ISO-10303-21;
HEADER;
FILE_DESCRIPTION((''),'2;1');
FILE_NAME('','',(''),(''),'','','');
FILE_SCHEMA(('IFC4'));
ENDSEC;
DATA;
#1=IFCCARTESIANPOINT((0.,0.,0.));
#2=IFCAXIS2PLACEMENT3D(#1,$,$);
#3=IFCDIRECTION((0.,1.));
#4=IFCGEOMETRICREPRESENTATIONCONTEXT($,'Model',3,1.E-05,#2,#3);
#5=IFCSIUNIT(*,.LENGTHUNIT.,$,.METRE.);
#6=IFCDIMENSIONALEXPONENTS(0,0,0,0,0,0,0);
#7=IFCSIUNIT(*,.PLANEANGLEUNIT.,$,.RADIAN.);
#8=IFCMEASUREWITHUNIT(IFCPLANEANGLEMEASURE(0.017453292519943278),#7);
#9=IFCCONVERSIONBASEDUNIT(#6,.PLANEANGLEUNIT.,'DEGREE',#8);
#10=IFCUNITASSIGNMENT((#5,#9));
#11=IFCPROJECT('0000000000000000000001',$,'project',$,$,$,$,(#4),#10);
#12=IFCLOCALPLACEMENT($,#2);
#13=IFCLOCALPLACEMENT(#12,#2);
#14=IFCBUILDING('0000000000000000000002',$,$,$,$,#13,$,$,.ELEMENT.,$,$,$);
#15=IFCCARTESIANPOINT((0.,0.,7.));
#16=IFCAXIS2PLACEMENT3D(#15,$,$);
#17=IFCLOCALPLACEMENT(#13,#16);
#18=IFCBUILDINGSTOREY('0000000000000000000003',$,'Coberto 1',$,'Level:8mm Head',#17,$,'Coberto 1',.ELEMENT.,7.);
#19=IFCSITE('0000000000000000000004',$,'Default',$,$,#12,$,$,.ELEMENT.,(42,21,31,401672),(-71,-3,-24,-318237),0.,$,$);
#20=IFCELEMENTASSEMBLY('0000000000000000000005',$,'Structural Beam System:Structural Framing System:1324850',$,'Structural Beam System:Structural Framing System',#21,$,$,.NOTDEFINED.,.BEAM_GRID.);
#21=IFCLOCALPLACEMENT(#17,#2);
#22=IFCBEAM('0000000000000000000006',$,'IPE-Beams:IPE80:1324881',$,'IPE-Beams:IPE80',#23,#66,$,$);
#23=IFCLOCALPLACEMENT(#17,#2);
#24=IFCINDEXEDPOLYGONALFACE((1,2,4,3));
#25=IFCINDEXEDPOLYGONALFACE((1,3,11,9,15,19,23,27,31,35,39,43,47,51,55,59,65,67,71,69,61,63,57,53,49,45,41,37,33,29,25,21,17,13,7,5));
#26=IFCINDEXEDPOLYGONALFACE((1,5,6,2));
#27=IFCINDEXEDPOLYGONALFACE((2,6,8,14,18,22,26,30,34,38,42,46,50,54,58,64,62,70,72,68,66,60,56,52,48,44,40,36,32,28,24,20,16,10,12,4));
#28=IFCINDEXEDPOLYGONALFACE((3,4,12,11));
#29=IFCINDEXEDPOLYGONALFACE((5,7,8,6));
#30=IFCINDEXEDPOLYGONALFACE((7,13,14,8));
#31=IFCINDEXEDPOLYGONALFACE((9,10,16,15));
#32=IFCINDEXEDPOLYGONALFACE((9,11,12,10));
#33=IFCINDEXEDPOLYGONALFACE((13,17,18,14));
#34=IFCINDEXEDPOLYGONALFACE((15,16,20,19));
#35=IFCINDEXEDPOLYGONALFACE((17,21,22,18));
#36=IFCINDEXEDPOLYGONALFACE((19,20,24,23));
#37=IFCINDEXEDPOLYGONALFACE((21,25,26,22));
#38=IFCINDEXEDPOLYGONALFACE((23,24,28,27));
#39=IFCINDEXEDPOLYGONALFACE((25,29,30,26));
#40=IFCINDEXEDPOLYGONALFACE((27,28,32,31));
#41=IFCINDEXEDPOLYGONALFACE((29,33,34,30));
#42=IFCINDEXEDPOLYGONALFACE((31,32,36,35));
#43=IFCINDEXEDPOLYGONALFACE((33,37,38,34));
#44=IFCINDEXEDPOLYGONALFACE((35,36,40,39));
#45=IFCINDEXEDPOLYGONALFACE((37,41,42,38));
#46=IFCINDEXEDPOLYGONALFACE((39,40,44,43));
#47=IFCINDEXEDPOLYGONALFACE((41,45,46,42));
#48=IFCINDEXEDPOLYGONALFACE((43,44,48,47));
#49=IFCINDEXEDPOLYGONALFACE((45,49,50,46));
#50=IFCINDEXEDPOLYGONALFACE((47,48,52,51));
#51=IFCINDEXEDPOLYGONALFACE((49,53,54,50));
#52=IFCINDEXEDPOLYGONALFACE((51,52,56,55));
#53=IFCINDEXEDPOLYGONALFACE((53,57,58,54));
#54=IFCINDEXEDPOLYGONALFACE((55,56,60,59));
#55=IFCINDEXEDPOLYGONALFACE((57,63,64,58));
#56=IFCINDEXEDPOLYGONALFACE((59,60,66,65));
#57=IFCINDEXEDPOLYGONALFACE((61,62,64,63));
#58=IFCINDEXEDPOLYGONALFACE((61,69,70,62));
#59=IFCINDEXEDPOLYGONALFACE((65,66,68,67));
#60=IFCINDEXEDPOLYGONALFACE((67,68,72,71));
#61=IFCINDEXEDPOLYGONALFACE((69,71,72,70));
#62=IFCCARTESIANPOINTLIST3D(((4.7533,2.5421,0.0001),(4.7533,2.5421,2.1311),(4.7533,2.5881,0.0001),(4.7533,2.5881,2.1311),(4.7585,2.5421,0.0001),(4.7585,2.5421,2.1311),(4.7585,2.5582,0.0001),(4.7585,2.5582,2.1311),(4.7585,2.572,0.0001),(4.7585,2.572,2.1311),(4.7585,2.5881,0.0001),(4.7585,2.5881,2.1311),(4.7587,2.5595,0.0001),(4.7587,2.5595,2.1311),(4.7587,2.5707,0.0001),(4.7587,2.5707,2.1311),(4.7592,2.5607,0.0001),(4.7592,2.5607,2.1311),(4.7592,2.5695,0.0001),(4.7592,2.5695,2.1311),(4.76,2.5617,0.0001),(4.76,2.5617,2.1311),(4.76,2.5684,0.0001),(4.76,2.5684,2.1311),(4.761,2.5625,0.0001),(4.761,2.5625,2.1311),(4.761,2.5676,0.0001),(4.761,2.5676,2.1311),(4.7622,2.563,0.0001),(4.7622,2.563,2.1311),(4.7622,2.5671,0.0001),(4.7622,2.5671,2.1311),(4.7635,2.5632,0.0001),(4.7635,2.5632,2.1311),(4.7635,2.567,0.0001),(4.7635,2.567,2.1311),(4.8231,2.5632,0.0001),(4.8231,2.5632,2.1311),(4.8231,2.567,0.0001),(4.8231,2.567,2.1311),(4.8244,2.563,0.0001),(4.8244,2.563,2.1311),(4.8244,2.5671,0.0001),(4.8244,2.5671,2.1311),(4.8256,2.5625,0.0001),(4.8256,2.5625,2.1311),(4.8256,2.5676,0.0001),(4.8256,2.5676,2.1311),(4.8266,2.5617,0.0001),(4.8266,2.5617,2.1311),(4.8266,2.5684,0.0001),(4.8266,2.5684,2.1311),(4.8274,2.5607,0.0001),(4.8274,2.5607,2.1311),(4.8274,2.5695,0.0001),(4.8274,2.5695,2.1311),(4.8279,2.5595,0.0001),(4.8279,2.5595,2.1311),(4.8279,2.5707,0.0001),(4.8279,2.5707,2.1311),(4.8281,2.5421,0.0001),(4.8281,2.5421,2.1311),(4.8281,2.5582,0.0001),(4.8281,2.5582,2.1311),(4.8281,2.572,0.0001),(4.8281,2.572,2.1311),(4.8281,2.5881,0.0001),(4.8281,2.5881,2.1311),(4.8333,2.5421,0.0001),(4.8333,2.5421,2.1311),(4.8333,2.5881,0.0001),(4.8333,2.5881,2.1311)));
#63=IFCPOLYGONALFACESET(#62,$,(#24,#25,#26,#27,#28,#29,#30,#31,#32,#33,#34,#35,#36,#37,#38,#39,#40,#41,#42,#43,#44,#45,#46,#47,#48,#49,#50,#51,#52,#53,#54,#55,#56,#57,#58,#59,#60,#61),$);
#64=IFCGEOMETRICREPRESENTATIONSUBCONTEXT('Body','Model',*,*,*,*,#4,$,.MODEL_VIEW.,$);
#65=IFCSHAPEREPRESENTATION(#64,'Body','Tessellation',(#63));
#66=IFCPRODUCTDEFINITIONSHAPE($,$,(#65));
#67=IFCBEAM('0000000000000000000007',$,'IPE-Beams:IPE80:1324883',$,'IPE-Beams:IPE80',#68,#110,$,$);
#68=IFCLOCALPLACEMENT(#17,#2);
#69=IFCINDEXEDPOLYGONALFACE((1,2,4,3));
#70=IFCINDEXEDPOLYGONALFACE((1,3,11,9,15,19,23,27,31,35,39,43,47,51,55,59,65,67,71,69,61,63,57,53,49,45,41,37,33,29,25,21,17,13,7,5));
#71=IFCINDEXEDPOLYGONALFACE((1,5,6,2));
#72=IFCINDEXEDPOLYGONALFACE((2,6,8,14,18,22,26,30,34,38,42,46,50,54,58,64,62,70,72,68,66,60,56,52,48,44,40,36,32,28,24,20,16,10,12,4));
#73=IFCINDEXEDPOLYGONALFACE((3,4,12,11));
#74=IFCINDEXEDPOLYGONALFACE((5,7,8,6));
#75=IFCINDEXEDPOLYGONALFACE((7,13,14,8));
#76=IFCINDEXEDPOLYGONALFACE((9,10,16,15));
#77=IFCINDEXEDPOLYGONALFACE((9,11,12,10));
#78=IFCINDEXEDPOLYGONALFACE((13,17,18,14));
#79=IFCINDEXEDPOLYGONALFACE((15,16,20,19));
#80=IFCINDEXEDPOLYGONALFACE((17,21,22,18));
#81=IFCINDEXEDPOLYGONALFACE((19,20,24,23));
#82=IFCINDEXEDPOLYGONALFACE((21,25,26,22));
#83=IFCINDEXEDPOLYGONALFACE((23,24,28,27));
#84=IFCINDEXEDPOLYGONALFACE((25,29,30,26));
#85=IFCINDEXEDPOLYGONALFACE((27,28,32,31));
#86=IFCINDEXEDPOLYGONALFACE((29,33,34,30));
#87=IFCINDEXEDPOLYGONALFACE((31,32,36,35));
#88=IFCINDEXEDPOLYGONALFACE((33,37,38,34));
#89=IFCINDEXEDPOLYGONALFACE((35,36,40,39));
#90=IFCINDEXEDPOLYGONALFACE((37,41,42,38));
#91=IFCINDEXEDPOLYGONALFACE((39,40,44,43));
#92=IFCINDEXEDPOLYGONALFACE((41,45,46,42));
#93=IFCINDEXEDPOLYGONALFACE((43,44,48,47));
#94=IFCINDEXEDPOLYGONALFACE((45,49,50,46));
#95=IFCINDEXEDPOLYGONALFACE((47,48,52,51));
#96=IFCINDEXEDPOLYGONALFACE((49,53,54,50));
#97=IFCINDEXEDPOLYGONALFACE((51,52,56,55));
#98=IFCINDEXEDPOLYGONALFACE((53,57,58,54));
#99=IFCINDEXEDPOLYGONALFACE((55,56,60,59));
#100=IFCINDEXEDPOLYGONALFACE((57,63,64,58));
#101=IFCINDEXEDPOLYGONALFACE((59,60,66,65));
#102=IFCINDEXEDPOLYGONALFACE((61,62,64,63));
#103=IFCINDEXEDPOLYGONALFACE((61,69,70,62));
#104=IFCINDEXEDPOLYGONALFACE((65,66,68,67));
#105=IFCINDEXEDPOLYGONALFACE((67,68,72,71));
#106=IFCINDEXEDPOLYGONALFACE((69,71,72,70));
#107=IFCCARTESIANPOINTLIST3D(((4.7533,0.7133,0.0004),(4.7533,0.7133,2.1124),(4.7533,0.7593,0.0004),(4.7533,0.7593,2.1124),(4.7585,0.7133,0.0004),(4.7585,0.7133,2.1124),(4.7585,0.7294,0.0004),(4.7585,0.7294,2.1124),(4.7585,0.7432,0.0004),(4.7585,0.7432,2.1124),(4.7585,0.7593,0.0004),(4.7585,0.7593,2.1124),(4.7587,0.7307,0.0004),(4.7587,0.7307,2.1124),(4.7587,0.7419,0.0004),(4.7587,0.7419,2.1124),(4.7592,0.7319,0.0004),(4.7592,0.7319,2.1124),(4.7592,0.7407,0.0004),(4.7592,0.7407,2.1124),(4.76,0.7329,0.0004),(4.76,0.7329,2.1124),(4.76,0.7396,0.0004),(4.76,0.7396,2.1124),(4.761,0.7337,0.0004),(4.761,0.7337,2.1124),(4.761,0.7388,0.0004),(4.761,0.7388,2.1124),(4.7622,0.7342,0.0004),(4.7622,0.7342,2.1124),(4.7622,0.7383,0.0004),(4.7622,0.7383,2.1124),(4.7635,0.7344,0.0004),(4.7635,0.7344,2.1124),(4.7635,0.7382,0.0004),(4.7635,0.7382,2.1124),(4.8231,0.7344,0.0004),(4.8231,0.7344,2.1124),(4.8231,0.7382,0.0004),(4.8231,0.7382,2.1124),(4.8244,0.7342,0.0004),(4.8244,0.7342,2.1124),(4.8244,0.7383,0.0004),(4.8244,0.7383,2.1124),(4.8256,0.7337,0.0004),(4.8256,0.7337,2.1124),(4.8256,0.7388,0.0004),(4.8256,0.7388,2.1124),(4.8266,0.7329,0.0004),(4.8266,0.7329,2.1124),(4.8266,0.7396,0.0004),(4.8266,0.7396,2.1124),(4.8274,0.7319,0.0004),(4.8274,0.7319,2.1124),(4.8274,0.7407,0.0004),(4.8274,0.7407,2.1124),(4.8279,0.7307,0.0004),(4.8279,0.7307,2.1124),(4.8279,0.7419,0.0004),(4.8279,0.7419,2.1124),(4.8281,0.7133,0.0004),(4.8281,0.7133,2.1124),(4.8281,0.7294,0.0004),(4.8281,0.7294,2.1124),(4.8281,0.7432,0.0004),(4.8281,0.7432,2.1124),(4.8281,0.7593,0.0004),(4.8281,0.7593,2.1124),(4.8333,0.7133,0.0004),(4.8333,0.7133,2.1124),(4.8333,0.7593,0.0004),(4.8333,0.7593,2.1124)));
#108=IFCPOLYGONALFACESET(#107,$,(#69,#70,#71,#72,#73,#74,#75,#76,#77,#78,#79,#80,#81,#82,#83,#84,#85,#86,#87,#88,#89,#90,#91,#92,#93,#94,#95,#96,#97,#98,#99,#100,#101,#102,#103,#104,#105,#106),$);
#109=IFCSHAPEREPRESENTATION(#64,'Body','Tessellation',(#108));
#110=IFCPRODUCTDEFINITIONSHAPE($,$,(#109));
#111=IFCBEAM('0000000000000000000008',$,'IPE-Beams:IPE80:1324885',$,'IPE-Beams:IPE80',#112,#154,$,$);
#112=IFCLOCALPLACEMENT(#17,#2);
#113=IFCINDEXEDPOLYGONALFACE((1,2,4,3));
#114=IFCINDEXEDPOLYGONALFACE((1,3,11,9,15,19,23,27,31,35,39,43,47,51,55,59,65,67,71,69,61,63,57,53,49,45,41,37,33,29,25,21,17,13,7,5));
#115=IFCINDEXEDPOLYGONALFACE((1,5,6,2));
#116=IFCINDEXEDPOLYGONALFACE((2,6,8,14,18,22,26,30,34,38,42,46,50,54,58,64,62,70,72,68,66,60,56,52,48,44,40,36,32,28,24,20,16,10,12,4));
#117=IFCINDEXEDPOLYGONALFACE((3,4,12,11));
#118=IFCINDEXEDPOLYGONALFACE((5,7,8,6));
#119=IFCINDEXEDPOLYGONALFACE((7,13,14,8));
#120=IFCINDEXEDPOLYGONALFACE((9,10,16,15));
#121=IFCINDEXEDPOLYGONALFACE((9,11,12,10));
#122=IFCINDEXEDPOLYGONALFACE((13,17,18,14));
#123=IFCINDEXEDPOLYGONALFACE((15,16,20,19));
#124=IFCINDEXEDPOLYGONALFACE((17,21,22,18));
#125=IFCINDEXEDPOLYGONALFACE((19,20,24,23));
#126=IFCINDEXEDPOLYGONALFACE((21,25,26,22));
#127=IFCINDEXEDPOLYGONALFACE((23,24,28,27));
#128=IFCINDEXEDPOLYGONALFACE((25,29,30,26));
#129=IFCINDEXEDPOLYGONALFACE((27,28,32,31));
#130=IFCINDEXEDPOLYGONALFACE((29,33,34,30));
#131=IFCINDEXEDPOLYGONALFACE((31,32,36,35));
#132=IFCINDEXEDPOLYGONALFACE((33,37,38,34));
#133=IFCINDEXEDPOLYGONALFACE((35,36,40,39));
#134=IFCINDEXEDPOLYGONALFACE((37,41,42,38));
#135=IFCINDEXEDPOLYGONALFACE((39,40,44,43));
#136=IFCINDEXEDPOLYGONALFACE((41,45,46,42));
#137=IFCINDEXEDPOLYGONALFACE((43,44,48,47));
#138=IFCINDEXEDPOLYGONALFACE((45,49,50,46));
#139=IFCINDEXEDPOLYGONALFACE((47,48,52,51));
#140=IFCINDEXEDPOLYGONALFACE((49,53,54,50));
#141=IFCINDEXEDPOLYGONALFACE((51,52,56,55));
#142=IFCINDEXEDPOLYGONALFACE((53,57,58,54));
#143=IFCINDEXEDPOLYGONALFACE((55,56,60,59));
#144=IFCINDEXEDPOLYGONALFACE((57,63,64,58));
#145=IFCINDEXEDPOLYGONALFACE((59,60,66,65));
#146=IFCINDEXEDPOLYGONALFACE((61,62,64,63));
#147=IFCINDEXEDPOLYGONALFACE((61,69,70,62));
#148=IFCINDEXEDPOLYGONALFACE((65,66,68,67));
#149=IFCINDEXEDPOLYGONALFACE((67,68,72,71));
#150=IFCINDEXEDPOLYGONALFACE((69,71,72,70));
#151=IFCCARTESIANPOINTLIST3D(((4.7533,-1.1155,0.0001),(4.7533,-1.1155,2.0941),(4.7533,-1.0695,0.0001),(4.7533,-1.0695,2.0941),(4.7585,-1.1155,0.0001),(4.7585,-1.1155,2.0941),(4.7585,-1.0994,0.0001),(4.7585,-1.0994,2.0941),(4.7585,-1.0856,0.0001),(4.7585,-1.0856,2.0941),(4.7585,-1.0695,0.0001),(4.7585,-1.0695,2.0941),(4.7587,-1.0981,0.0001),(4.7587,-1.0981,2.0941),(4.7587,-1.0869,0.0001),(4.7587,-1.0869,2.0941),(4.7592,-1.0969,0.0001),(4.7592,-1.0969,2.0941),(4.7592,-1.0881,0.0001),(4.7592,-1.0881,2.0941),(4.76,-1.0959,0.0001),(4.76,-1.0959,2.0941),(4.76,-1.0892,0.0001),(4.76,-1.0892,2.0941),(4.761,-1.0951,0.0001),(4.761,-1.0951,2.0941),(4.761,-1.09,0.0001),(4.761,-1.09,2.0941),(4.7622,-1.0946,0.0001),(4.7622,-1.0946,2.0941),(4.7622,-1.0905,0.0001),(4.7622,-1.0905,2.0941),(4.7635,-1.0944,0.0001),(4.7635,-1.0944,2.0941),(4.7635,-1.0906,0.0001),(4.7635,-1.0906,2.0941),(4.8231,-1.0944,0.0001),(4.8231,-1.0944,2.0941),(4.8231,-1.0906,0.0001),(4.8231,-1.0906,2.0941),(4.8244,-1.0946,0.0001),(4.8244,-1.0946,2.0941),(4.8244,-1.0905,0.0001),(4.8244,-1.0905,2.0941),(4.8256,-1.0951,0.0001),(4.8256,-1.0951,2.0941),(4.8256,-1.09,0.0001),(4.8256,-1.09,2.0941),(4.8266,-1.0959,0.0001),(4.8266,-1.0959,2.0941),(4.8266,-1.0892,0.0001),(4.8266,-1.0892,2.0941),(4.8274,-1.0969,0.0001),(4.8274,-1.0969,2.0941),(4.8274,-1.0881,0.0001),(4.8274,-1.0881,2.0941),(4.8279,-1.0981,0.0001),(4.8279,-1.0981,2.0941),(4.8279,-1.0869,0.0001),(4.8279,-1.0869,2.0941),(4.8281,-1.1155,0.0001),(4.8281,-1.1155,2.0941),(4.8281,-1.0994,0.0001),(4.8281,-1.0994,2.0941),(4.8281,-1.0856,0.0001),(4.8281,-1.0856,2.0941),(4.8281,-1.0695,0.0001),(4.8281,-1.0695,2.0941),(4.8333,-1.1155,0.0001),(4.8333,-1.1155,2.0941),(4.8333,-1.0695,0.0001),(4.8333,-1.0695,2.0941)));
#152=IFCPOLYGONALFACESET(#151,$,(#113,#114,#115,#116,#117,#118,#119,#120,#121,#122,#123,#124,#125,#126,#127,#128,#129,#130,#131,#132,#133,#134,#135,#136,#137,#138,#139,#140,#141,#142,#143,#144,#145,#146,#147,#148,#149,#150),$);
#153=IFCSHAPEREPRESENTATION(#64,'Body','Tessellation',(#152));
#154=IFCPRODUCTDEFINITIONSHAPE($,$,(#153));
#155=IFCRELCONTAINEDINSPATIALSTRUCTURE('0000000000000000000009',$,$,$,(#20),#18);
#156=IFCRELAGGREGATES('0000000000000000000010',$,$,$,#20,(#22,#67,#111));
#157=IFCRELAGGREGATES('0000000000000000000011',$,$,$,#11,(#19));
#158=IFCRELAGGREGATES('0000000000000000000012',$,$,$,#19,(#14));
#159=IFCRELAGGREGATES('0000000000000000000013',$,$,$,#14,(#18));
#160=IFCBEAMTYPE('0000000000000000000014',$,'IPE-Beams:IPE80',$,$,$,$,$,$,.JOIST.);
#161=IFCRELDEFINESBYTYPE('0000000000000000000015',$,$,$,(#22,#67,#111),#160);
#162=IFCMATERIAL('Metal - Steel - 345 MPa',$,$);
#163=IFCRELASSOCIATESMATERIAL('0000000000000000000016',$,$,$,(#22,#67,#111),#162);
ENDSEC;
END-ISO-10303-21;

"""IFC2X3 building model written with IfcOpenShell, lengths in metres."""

from ifc_helpers import new_model, entity, si_unit, converted_unit, direction, frame, frame_2d, origin, place, context, subcontext, project, spatial, polyline, circle_curve, parameter, trimmed, segment, composite_curve, outline, extrude, material, type_object, element, aggregate, save


model = new_model("IFC2X3")

# Units and contexts
model_context = context("Model", 3, precision=1e-05, world=origin(), true_north=direction((0.0, 1.0)))
body_context = subcontext(model_context, "Body", "Model", "MODEL_VIEW")
ifc_project = project(units=[si_unit("LENGTHUNIT", "METRE"), converted_unit("PLANEANGLEUNIT", "DEGREE", entity("IfcPlaneAngleMeasure", 0.017453292519943278), si_unit("PLANEANGLEUNIT", "RADIAN"), dimensions=[0, 0, 0, 0, 0, 0, 0])], contexts=[model_context])

# Site, building, storey
site_placement = place(None, origin())
site = spatial("IfcSite", under=ifc_project, at=site_placement, Name="Default", CompositionType="ELEMENT", RefLatitude=(42, 21, 31, 401672), RefLongitude=(-71, -3, -24, -318237), RefElevation=0.0)
building_placement = place(site_placement, origin())
building = spatial("IfcBuilding", under=site, at=building_placement, CompositionType="ELEMENT")
storey_placement = place(building_placement, frame((0.0, 0.0, 7.0)))
storey = spatial("IfcBuildingStorey", under=building, at=storey_placement, Name="Coberto 1", ObjectType="Level:8mm Head", LongName="Coberto 1", CompositionType="ELEMENT", Elevation=7.0)

# Shared definitions
ifc_material_1 = material(Name="Metal - Steel - 345 MPa")

# Element assembly, beams
assembly_1_placement = place(storey_placement, origin())
assembly_1 = element("IfcElementAssembly", 1, at=assembly_1_placement, inside=storey, Name="Structural Beam System:Structural Framing System:1324850", ObjectType="Structural Beam System:Structural Framing System", AssemblyPlace="NOTDEFINED", PredefinedType="BEAM_GRID")
beam_type_1 = type_object("IfcBeamType", Name="IPE-Beams:IPE80", PredefinedType="JOIST")
beam_1_placement = place(assembly_1_placement, frame((4.7533, 2.5651, 2.1312), z_axis=(1.0, 0.0, 0.0), x_axis=(0.0, 0.0, -1.0)))
beam_1 = element("IfcBeam", 2, at=beam_1_placement, type_object=beam_type_1, material=ifc_material_1, Name="IPE-Beams:IPE80:1324881", ObjectType="IPE-Beams:IPE80", context=body_context, shape_type="SweptSolid", body=[
    extrude(outline(composite_curve([segment(polyline([(0.0348, -0.023), (0.04, -0.023)]), True, "CONTINUOUS"), segment(polyline([(0.04, -0.023), (0.04, 0.023)]), True, "CONTINUOUS"), segment(polyline([(0.04, 0.023), (0.0348, 0.023)]), True, "CONTINUOUS"), segment(polyline([(0.0348, 0.023), (0.0348, 0.0069)]), True, "CONTINUOUS"), segment(trimmed(circle_curve(frame_2d((0.0298, 0.0069), x_axis=(1.0, 0.0)), 0.005), [parameter(270.0)], [parameter(0.0)], True, "PARAMETER"), False, "CONTINUOUS"), segment(polyline([(0.0298, 0.0019), (-0.0298, 0.0019)]), True, "CONTINUOUS"), segment(trimmed(circle_curve(frame_2d((-0.0298, 0.0069), x_axis=(0.0, -1.0)), 0.005), [parameter(270.0)], [parameter(0.0)], True, "PARAMETER"), False, "CONTINUOUS"), segment(polyline([(-0.0348, 0.0069), (-0.0348, 0.023)]), True, "CONTINUOUS"), segment(polyline([(-0.0348, 0.023), (-0.04, 0.023)]), True, "CONTINUOUS"), segment(polyline([(-0.04, 0.023), (-0.04, -0.023)]), True, "CONTINUOUS"), segment(polyline([(-0.04, -0.023), (-0.0348, -0.023)]), True, "CONTINUOUS"), segment(polyline([(-0.0348, -0.023), (-0.0348, -0.0069)]), True, "CONTINUOUS"), segment(trimmed(circle_curve(frame_2d((-0.0298, -0.0069), x_axis=(-1.0, 0.0)), 0.005), [parameter(270.0)], [parameter(0.0)], True, "PARAMETER"), False, "CONTINUOUS"), segment(polyline([(-0.0298, -0.0019), (0.0298, -0.0019)]), True, "CONTINUOUS"), segment(trimmed(circle_curve(frame_2d((0.0298, -0.0069), x_axis=(0.0, 1.0)), 0.005), [parameter(270.0)], [parameter(0.0)], True, "PARAMETER"), False, "CONTINUOUS"), segment(polyline([(0.0348, -0.0069), (0.0348, -0.023)]), True, "CONTINUOUS")], self_intersect=False)), frame((0.0001, 0.0, 0.04), z_axis=(1.0, 0.0, 0.0), x_axis=(0.0, 0.0, -1.0)), (0.0, 0.0, 1.0), 2.131),
])
beam_2_placement = place(assembly_1_placement, frame((4.7533, 0.7363, 2.1127), z_axis=(1.0, 0.0, 0.0), x_axis=(0.0, 0.0, -1.0)))
beam_2 = element("IfcBeam", 3, at=beam_2_placement, type_object=beam_type_1, material=ifc_material_1, Name="IPE-Beams:IPE80:1324883", ObjectType="IPE-Beams:IPE80", context=body_context, shape_type="SweptSolid", body=[
    extrude(outline(composite_curve([segment(polyline([(0.0348, -0.023), (0.04, -0.023)]), True, "CONTINUOUS"), segment(polyline([(0.04, -0.023), (0.04, 0.023)]), True, "CONTINUOUS"), segment(polyline([(0.04, 0.023), (0.0348, 0.023)]), True, "CONTINUOUS"), segment(polyline([(0.0348, 0.023), (0.0348, 0.0069)]), True, "CONTINUOUS"), segment(trimmed(circle_curve(frame_2d((0.0298, 0.0069), x_axis=(1.0, 0.0)), 0.005), [parameter(270.0)], [parameter(0.0)], True, "PARAMETER"), False, "CONTINUOUS"), segment(polyline([(0.0298, 0.0019), (-0.0298, 0.0019)]), True, "CONTINUOUS"), segment(trimmed(circle_curve(frame_2d((-0.0298, 0.0069), x_axis=(0.0, -1.0)), 0.005), [parameter(270.0)], [parameter(0.0)], True, "PARAMETER"), False, "CONTINUOUS"), segment(polyline([(-0.0348, 0.0069), (-0.0348, 0.023)]), True, "CONTINUOUS"), segment(polyline([(-0.0348, 0.023), (-0.04, 0.023)]), True, "CONTINUOUS"), segment(polyline([(-0.04, 0.023), (-0.04, -0.023)]), True, "CONTINUOUS"), segment(polyline([(-0.04, -0.023), (-0.0348, -0.023)]), True, "CONTINUOUS"), segment(polyline([(-0.0348, -0.023), (-0.0348, -0.0069)]), True, "CONTINUOUS"), segment(trimmed(circle_curve(frame_2d((-0.0298, -0.0069), x_axis=(-1.0, 0.0)), 0.005), [parameter(270.0)], [parameter(0.0)], True, "PARAMETER"), False, "CONTINUOUS"), segment(polyline([(-0.0298, -0.0019), (0.0298, -0.0019)]), True, "CONTINUOUS"), segment(trimmed(circle_curve(frame_2d((0.0298, -0.0069), x_axis=(0.0, 1.0)), 0.005), [parameter(270.0)], [parameter(0.0)], True, "PARAMETER"), False, "CONTINUOUS"), segment(polyline([(0.0348, -0.0069), (0.0348, -0.023)]), True, "CONTINUOUS")], self_intersect=False)), frame((0.0004, 0.0, 0.04), z_axis=(1.0, 0.0, 0.0), x_axis=(0.0, 0.0, -1.0)), (0.0, 0.0, 1.0), 2.112),
])
beam_3_placement = place(assembly_1_placement, frame((4.7533, -1.0925, 2.0942), z_axis=(1.0, 0.0, 0.0), x_axis=(0.0, 0.0, -1.0)))
beam_3 = element("IfcBeam", 4, at=beam_3_placement, type_object=beam_type_1, material=ifc_material_1, Name="IPE-Beams:IPE80:1324885", ObjectType="IPE-Beams:IPE80", context=body_context, shape_type="SweptSolid", body=[
    extrude(outline(composite_curve([segment(polyline([(0.0348, -0.023), (0.04, -0.023)]), True, "CONTINUOUS"), segment(polyline([(0.04, -0.023), (0.04, 0.023)]), True, "CONTINUOUS"), segment(polyline([(0.04, 0.023), (0.0348, 0.023)]), True, "CONTINUOUS"), segment(polyline([(0.0348, 0.023), (0.0348, 0.0069)]), True, "CONTINUOUS"), segment(trimmed(circle_curve(frame_2d((0.0298, 0.0069), x_axis=(1.0, 0.0)), 0.005), [parameter(270.0)], [parameter(0.0)], True, "PARAMETER"), False, "CONTINUOUS"), segment(polyline([(0.0298, 0.0019), (-0.0298, 0.0019)]), True, "CONTINUOUS"), segment(trimmed(circle_curve(frame_2d((-0.0298, 0.0069), x_axis=(0.0, -1.0)), 0.005), [parameter(270.0)], [parameter(0.0)], True, "PARAMETER"), False, "CONTINUOUS"), segment(polyline([(-0.0348, 0.0069), (-0.0348, 0.023)]), True, "CONTINUOUS"), segment(polyline([(-0.0348, 0.023), (-0.04, 0.023)]), True, "CONTINUOUS"), segment(polyline([(-0.04, 0.023), (-0.04, -0.023)]), True, "CONTINUOUS"), segment(polyline([(-0.04, -0.023), (-0.0348, -0.023)]), True, "CONTINUOUS"), segment(polyline([(-0.0348, -0.023), (-0.0348, -0.0069)]), True, "CONTINUOUS"), segment(trimmed(circle_curve(frame_2d((-0.0298, -0.0069), x_axis=(-1.0, 0.0)), 0.005), [parameter(270.0)], [parameter(0.0)], True, "PARAMETER"), False, "CONTINUOUS"), segment(polyline([(-0.0298, -0.0019), (0.0298, -0.0019)]), True, "CONTINUOUS"), segment(trimmed(circle_curve(frame_2d((0.0298, -0.0069), x_axis=(0.0, 1.0)), 0.005), [parameter(270.0)], [parameter(0.0)], True, "PARAMETER"), False, "CONTINUOUS"), segment(polyline([(0.0348, -0.0069), (0.0348, -0.023)]), True, "CONTINUOUS")], self_intersect=False)), frame((0.0001, 0.0, 0.04), z_axis=(1.0, 0.0, 0.0), x_axis=(0.0, 0.0, -1.0)), (0.0, 0.0, 1.0), 2.094),
])
aggregate(assembly_1, [beam_1, beam_2, beam_3])

save(model, "model.ifc")
